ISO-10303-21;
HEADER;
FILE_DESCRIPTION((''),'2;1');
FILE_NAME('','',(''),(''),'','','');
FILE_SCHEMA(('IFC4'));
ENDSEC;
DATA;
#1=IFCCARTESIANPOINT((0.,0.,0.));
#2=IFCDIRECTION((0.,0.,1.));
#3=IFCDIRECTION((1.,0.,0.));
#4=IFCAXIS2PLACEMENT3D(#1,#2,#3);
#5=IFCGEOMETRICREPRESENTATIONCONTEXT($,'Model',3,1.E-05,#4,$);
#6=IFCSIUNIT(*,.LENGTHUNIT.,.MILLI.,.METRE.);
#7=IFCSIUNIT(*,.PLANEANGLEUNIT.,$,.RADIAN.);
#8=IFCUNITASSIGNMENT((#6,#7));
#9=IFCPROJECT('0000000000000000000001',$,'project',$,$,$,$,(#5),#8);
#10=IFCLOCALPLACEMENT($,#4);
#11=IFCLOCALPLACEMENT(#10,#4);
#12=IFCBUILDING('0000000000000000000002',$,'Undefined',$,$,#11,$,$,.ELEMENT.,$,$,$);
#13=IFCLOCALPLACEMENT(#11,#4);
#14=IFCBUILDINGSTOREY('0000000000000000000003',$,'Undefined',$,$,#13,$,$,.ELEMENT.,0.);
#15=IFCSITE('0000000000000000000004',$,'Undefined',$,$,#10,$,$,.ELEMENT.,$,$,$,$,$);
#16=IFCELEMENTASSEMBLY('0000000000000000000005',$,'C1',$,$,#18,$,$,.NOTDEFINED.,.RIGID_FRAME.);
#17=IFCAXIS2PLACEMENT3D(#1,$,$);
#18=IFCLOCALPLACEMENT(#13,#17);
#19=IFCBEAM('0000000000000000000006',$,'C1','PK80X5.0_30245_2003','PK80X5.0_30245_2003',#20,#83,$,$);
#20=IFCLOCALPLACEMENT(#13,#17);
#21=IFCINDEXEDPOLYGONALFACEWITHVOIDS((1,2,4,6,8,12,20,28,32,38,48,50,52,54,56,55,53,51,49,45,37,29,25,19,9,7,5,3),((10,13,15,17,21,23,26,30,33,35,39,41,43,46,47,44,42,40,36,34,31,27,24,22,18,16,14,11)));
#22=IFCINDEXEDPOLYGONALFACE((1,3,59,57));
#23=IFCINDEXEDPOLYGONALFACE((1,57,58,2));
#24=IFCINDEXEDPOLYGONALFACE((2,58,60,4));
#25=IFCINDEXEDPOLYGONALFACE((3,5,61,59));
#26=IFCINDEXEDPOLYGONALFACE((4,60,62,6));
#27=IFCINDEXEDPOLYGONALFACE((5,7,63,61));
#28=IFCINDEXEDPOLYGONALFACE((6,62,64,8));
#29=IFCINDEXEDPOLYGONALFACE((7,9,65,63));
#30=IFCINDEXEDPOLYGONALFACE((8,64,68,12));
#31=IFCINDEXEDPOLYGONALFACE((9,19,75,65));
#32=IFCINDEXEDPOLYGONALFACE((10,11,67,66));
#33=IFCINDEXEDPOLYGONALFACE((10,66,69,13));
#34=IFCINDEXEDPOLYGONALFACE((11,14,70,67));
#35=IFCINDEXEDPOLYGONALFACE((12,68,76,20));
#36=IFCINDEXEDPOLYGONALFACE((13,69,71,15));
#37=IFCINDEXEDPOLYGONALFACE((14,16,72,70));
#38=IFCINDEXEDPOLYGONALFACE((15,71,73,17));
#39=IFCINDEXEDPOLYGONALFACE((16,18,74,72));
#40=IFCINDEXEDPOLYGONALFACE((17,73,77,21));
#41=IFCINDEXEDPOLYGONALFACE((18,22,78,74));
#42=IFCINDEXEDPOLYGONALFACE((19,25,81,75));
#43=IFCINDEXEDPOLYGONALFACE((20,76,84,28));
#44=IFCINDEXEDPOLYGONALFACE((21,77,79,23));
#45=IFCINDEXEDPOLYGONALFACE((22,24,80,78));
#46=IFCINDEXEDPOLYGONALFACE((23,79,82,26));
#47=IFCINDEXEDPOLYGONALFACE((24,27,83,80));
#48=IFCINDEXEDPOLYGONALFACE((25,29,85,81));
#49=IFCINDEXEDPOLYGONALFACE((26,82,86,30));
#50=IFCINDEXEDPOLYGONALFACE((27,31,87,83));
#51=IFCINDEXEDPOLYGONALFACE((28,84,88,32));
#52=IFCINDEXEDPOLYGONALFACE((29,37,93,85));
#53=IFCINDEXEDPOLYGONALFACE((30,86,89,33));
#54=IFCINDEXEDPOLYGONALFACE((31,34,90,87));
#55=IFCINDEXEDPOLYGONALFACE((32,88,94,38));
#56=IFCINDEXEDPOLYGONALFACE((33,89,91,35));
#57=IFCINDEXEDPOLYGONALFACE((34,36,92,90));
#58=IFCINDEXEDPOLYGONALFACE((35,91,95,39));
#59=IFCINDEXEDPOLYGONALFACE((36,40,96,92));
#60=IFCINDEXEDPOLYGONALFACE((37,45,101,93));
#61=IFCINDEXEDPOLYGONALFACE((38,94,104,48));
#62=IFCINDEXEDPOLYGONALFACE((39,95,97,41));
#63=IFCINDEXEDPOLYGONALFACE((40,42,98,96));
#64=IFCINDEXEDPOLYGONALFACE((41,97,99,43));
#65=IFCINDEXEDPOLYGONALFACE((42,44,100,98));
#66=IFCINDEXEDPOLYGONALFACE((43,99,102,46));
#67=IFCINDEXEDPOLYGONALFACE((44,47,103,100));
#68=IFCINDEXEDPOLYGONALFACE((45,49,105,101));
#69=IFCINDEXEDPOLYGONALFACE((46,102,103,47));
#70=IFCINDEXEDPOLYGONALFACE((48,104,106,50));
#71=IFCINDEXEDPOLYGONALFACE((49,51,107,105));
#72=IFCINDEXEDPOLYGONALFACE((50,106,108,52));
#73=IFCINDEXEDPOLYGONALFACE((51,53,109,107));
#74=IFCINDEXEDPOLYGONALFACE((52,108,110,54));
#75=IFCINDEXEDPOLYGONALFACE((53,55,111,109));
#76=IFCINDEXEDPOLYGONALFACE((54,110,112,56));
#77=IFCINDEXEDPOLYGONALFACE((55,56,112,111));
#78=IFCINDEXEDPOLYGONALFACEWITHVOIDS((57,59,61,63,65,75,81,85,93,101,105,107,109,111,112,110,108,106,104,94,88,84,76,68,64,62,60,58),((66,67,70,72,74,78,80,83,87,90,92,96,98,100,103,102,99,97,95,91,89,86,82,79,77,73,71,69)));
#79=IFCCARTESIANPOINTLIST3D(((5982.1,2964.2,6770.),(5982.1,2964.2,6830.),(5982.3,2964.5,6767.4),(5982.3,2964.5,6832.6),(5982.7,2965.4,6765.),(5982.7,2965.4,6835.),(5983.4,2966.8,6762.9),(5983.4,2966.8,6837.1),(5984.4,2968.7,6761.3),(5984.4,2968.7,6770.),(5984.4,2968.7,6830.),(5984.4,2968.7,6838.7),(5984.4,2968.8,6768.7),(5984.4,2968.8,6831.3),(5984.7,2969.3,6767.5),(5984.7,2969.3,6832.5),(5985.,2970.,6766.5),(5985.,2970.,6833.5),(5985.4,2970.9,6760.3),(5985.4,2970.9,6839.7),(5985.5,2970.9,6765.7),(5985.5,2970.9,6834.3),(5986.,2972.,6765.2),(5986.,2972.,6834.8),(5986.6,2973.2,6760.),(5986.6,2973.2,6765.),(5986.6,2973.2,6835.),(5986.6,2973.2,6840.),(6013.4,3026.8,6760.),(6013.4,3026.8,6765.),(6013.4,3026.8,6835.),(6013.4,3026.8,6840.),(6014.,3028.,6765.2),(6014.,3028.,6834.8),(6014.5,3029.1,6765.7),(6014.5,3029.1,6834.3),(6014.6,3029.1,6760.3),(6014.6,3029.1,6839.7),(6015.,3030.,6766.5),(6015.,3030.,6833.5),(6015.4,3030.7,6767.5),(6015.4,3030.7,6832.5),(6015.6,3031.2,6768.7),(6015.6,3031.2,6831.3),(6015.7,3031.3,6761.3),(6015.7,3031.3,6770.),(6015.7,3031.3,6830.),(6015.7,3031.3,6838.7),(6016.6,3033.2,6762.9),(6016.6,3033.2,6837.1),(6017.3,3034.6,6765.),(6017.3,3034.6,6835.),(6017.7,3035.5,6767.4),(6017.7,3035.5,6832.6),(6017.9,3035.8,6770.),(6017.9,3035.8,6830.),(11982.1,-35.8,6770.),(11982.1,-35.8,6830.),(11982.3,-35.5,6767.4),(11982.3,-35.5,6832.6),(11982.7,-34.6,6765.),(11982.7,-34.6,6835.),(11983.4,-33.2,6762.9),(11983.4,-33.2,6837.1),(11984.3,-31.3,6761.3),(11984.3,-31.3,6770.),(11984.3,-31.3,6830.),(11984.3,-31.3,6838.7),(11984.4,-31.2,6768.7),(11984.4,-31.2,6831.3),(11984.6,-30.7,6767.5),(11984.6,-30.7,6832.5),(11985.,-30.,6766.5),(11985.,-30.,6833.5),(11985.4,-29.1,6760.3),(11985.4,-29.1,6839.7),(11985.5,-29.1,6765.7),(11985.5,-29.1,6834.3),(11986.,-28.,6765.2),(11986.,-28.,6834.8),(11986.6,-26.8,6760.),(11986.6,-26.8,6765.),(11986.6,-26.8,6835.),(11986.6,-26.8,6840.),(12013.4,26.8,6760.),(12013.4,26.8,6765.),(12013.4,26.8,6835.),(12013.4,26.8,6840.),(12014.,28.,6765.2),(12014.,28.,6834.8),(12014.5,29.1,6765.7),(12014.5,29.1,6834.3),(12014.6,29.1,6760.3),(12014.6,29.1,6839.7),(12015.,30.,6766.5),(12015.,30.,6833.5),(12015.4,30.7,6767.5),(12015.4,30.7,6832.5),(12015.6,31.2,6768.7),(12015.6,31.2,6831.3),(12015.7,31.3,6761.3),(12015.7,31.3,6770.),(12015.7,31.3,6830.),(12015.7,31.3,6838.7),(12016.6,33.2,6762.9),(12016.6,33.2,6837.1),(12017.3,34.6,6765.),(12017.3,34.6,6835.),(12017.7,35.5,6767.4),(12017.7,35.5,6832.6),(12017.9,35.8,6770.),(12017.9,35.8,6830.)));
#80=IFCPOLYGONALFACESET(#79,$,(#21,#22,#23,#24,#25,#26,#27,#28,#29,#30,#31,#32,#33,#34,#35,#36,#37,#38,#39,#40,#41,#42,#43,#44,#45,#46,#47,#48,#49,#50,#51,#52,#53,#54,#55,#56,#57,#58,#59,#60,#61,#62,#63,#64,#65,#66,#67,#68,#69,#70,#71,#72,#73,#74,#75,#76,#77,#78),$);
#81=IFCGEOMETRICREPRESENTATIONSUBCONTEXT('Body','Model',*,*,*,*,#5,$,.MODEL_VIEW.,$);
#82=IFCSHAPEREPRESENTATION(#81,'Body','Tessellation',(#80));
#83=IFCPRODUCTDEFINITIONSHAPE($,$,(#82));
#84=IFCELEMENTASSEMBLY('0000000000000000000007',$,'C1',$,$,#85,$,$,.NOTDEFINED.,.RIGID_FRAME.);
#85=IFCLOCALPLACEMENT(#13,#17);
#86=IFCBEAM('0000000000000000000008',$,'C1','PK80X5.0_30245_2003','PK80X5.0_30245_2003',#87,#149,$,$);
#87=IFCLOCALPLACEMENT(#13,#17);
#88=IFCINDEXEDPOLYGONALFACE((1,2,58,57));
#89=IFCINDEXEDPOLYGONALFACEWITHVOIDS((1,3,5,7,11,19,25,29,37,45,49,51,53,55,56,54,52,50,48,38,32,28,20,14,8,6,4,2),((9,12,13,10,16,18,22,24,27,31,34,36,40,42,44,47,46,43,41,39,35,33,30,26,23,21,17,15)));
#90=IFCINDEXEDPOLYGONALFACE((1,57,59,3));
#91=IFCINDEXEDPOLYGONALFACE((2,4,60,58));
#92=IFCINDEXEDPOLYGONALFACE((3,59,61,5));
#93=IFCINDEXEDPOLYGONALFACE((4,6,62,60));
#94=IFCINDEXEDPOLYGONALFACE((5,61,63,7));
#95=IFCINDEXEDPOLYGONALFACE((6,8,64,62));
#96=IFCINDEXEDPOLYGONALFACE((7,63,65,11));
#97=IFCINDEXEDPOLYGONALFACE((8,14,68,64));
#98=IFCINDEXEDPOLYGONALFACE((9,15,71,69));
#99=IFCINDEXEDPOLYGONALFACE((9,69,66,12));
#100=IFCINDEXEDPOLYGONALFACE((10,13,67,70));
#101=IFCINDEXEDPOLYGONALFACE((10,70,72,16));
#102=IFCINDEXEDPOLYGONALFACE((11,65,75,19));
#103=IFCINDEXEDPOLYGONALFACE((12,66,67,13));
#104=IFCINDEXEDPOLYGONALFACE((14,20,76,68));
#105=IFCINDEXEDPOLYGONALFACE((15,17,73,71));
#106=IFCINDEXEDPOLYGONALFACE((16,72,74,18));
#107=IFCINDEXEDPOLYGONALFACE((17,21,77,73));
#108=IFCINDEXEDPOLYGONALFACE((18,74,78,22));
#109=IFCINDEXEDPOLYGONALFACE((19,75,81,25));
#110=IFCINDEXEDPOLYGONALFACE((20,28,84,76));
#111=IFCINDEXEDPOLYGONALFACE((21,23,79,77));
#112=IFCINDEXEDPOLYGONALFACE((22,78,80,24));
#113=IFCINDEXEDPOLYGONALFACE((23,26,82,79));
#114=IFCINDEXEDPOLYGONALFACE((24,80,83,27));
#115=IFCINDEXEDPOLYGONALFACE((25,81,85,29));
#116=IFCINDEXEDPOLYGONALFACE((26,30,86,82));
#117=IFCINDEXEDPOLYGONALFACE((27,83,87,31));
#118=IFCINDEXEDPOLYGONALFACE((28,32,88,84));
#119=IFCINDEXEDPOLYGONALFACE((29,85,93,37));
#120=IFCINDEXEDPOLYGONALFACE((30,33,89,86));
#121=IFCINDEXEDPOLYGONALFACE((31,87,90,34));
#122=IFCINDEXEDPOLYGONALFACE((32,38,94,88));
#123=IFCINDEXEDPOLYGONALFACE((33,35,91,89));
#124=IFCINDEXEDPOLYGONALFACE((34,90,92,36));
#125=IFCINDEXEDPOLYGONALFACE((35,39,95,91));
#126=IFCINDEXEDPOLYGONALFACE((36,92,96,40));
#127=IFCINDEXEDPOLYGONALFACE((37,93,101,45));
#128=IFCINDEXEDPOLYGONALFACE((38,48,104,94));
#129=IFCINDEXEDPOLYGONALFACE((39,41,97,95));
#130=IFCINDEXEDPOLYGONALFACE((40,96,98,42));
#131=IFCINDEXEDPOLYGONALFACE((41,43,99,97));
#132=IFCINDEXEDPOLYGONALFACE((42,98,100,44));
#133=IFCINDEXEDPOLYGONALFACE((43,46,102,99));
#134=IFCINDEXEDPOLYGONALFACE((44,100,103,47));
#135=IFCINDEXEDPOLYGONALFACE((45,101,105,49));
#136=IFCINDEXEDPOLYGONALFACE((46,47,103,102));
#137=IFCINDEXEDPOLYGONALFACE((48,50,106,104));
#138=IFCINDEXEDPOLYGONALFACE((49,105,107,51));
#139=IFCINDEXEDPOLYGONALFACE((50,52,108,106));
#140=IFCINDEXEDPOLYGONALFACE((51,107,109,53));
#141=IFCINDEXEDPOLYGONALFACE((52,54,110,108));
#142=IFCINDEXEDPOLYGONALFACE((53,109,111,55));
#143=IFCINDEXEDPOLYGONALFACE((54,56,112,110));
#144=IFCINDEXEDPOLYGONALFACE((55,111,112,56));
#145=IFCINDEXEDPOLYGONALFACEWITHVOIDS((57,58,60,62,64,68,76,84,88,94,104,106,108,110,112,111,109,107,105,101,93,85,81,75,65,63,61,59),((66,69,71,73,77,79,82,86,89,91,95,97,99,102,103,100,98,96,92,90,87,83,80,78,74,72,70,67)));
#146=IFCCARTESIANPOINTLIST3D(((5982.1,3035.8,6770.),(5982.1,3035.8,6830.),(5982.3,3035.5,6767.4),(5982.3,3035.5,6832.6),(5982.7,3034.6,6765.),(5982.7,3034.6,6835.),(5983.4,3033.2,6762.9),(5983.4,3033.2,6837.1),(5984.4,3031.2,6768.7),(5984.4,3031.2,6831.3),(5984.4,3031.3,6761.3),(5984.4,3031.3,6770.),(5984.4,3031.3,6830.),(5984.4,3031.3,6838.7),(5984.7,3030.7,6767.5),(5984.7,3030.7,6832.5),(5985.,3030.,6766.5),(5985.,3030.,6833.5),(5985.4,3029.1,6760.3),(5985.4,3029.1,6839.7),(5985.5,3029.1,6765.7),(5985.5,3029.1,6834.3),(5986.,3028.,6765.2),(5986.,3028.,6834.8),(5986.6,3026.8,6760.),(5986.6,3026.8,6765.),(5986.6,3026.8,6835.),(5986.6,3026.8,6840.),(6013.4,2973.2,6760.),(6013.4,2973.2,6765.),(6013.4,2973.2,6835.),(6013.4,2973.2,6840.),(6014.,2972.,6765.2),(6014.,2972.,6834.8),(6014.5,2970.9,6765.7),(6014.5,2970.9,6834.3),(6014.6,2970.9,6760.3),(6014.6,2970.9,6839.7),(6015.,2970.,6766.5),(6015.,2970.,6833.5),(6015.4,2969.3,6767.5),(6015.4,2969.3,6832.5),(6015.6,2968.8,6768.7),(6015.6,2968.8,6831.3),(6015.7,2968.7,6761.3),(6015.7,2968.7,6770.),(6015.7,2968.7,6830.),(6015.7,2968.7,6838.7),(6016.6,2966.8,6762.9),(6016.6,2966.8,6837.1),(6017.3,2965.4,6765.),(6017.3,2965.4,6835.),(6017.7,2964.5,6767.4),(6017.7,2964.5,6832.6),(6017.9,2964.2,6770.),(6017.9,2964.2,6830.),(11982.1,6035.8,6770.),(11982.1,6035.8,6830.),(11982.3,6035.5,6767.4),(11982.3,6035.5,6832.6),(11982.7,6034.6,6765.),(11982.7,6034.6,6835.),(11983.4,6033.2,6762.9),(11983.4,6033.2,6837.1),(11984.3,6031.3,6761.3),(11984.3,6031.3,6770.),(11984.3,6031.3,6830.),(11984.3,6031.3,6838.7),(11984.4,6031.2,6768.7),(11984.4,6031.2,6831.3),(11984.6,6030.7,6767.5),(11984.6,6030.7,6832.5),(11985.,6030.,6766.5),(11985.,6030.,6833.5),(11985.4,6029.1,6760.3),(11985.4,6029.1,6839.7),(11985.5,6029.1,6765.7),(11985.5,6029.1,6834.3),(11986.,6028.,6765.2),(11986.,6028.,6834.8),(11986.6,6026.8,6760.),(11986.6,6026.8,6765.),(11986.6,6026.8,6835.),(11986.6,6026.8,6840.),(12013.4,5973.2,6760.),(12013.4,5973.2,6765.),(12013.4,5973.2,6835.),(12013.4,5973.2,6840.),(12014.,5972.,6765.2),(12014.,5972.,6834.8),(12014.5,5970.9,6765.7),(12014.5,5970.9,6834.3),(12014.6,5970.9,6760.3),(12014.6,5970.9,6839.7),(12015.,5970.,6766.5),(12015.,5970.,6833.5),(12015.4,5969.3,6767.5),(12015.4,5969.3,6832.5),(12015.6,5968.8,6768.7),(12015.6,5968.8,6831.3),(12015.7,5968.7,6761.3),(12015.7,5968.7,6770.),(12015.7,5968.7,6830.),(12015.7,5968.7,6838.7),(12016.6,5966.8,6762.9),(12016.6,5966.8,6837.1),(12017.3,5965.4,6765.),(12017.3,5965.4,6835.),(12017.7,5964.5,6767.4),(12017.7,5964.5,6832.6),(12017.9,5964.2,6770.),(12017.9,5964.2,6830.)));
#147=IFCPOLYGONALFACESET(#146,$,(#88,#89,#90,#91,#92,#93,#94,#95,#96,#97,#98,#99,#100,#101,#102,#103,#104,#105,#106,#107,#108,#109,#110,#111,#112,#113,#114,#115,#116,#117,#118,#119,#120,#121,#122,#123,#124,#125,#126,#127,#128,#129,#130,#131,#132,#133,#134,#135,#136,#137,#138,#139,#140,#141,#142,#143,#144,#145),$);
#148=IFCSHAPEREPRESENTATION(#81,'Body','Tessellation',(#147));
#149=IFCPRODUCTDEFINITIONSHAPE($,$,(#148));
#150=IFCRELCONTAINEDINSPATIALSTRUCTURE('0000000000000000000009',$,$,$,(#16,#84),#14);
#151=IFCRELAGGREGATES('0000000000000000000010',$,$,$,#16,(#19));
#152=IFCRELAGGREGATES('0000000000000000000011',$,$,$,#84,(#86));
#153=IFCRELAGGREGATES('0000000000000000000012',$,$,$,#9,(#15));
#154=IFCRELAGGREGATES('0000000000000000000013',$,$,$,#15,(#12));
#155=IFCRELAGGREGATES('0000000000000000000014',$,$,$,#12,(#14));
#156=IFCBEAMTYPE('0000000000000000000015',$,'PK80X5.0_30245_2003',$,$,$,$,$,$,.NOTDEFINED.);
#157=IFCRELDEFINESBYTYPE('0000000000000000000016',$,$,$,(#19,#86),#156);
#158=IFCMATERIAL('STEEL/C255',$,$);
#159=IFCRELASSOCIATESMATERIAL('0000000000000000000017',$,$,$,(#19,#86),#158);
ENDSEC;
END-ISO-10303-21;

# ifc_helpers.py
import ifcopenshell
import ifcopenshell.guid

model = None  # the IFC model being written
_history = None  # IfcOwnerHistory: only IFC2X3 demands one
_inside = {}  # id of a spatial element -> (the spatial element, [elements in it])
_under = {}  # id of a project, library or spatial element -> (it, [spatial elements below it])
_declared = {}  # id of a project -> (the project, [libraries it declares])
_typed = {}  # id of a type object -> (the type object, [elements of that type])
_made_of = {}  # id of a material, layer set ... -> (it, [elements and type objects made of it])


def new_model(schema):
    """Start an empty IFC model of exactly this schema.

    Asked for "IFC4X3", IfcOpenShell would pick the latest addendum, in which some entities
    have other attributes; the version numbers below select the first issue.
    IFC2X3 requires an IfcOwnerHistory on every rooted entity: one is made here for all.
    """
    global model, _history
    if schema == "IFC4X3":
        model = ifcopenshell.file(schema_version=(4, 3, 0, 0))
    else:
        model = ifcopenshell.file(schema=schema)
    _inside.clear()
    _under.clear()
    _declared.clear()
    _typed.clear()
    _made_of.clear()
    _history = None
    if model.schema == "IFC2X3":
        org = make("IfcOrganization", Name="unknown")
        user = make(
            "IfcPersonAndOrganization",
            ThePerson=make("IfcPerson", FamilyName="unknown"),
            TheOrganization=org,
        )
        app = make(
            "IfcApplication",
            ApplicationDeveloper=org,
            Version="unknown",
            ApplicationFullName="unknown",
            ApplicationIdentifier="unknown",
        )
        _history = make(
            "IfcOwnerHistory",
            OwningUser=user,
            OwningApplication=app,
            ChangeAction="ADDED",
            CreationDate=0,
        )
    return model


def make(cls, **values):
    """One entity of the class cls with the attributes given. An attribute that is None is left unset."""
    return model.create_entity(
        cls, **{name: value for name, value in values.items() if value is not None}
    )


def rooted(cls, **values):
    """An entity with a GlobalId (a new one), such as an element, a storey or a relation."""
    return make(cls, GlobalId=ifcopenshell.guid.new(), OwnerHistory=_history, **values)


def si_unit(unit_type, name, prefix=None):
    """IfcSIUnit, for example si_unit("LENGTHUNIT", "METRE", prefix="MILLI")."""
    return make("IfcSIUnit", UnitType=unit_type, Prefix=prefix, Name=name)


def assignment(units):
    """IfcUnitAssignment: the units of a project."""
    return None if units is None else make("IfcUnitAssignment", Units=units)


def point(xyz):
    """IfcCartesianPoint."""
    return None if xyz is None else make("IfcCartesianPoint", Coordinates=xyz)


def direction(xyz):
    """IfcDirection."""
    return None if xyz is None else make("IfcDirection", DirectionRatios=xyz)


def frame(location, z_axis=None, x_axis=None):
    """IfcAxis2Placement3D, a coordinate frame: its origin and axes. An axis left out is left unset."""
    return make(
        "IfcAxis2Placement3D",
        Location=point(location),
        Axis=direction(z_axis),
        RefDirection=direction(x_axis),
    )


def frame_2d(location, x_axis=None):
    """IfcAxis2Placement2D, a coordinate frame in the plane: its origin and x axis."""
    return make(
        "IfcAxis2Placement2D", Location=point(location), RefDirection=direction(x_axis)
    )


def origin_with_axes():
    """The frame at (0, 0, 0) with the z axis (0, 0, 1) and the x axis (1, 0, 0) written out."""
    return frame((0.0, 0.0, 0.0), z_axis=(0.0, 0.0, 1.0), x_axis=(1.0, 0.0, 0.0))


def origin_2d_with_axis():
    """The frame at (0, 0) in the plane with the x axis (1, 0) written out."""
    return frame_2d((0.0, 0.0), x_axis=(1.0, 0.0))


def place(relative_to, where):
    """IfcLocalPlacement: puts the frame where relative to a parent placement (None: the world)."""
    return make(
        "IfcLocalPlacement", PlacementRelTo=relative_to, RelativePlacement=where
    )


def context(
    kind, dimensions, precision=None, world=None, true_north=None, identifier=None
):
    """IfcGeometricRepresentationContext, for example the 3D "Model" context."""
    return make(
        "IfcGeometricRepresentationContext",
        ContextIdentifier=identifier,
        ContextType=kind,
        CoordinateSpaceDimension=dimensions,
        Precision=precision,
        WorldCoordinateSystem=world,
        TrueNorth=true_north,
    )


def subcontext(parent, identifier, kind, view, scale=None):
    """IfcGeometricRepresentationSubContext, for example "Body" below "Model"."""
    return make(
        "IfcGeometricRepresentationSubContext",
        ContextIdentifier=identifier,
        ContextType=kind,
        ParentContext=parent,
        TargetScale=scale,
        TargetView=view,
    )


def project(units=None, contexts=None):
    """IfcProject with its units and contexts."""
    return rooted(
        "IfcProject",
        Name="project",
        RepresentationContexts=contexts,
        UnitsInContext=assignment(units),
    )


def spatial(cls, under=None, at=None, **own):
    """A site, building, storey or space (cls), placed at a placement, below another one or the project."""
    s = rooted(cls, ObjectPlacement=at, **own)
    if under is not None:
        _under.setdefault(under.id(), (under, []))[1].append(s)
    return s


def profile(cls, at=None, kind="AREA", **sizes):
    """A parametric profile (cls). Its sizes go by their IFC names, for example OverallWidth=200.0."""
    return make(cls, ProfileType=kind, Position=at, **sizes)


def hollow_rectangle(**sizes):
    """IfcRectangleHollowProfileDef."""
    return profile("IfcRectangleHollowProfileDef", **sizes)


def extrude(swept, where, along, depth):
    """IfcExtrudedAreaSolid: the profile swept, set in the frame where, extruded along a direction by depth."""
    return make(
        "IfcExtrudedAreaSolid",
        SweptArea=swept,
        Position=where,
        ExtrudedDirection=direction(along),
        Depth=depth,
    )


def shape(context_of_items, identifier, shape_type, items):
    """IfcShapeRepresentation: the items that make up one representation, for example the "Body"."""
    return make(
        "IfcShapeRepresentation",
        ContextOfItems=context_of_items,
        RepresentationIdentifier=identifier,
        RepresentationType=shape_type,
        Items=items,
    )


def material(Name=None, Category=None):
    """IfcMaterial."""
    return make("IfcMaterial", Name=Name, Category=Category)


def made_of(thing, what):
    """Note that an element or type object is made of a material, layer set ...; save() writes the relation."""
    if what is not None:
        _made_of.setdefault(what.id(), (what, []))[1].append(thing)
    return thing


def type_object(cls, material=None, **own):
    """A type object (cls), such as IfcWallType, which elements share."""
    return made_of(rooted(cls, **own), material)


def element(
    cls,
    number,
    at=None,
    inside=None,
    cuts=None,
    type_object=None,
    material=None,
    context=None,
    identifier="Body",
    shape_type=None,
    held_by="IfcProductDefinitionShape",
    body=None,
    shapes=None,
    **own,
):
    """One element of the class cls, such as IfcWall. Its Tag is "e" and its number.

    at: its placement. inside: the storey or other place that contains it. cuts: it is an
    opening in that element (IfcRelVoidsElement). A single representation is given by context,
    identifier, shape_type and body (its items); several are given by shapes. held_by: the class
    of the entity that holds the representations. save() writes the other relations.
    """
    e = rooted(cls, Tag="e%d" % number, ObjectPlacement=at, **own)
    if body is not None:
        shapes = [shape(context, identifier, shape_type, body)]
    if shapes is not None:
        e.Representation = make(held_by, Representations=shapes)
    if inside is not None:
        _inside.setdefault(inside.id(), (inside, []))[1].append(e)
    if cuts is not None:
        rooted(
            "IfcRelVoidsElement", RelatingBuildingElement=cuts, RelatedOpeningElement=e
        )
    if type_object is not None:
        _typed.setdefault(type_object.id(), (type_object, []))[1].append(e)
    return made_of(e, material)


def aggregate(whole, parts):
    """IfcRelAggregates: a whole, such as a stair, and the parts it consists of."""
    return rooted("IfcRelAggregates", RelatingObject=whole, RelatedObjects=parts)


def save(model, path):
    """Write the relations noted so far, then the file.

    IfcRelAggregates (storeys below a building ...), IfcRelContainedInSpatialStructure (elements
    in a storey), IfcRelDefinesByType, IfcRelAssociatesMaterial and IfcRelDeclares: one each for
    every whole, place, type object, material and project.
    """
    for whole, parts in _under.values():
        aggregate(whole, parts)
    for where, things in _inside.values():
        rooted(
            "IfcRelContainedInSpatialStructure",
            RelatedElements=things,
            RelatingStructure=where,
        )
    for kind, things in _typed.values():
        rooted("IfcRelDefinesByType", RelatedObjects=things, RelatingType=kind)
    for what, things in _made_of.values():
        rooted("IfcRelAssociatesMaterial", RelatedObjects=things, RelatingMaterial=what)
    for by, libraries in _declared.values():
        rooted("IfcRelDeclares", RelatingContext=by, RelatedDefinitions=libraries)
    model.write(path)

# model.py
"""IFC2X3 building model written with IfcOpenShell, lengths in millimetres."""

from ifc_helpers import new_model, si_unit, frame, origin_with_axes, origin_2d_with_axis, place, context, subcontext, project, spatial, hollow_rectangle, extrude, material, type_object, element, aggregate, save


model = new_model("IFC2X3")

# Units and contexts
model_context = context("Model", 3, precision=1e-05, world=origin_with_axes())
body_context = subcontext(model_context, "Body", "Model", "MODEL_VIEW")
ifc_project = project(units=[si_unit("LENGTHUNIT", "METRE", prefix="MILLI"), si_unit("PLANEANGLEUNIT", "RADIAN")], contexts=[model_context])

# Site, building, storey
site_placement = place(None, origin_with_axes())
site = spatial("IfcSite", under=ifc_project, at=site_placement, Name="Undefined", CompositionType="ELEMENT")
building_placement = place(site_placement, origin_with_axes())
building = spatial("IfcBuilding", under=site, at=building_placement, Name="Undefined", CompositionType="ELEMENT")
storey_placement = place(building_placement, origin_with_axes())
storey = spatial("IfcBuildingStorey", under=building, at=storey_placement, Name="Undefined", CompositionType="ELEMENT", Elevation=0.0)

# Element assemblies, beams
assembly_1_placement = place(storey_placement, origin_with_axes())
assembly_1 = element("IfcElementAssembly", 1, at=assembly_1_placement, inside=storey, Name="C1", AssemblyPlace="NOTDEFINED", PredefinedType="RIGID_FRAME")
ifc_material_1 = material(Name="STEEL/C255")
beam_type_1 = type_object("IfcBeamType", Name="PK80X5.0_30245_2003", PredefinedType="NOTDEFINED")
beam_1_placement = place(assembly_1_placement, frame((6000.0, 3000.0, 6800.0), z_axis=(0.0, 0.0, -1.0), x_axis=(0.894427, -0.447214, 0.0)))
beam_1 = element("IfcBeam", 2, at=beam_1_placement, type_object=beam_type_1, material=ifc_material_1, Name="C1", Description="PK80X5.0_30245_2003", ObjectType="PK80X5.0_30245_2003", context=body_context, shape_type="SweptSolid", body=[
    extrude(hollow_rectangle(XDim=80.0, YDim=80.0, WallThickness=5.0, InnerFilletRadius=5.0, OuterFilletRadius=10.0, at=origin_2d_with_axis()), frame((6708.2, 0.0, 0.0), z_axis=(-1.0, 0.0, 0.0), x_axis=(0.0, -1.0, 0.0)), (0.0, 0.0, 1.0), 6708.2),
])
aggregate(assembly_1, [beam_1])
assembly_2_placement = place(storey_placement, origin_with_axes())
assembly_2 = element("IfcElementAssembly", 3, at=assembly_2_placement, inside=storey, Name="C1", AssemblyPlace="NOTDEFINED", PredefinedType="RIGID_FRAME")
beam_2_placement = place(assembly_2_placement, frame((6000.0, 3000.0, 6800.0), z_axis=(0.0, 0.0, -1.0), x_axis=(0.894427, 0.447214, 0.0)))
beam_2 = element("IfcBeam", 4, at=beam_2_placement, type_object=beam_type_1, material=ifc_material_1, Name="C1", Description="PK80X5.0_30245_2003", ObjectType="PK80X5.0_30245_2003", context=body_context, shape_type="SweptSolid", body=[
    extrude(hollow_rectangle(XDim=80.0, YDim=80.0, WallThickness=5.0, InnerFilletRadius=5.0, OuterFilletRadius=10.0, at=origin_2d_with_axis()), frame((6708.2, 0.0, 0.0), z_axis=(-1.0, 0.0, 0.0), x_axis=(0.0, -1.0, 0.0)), (0.0, 0.0, 1.0), 6708.2),
])
aggregate(assembly_2, [beam_2])

save(model, "model.ifc")
